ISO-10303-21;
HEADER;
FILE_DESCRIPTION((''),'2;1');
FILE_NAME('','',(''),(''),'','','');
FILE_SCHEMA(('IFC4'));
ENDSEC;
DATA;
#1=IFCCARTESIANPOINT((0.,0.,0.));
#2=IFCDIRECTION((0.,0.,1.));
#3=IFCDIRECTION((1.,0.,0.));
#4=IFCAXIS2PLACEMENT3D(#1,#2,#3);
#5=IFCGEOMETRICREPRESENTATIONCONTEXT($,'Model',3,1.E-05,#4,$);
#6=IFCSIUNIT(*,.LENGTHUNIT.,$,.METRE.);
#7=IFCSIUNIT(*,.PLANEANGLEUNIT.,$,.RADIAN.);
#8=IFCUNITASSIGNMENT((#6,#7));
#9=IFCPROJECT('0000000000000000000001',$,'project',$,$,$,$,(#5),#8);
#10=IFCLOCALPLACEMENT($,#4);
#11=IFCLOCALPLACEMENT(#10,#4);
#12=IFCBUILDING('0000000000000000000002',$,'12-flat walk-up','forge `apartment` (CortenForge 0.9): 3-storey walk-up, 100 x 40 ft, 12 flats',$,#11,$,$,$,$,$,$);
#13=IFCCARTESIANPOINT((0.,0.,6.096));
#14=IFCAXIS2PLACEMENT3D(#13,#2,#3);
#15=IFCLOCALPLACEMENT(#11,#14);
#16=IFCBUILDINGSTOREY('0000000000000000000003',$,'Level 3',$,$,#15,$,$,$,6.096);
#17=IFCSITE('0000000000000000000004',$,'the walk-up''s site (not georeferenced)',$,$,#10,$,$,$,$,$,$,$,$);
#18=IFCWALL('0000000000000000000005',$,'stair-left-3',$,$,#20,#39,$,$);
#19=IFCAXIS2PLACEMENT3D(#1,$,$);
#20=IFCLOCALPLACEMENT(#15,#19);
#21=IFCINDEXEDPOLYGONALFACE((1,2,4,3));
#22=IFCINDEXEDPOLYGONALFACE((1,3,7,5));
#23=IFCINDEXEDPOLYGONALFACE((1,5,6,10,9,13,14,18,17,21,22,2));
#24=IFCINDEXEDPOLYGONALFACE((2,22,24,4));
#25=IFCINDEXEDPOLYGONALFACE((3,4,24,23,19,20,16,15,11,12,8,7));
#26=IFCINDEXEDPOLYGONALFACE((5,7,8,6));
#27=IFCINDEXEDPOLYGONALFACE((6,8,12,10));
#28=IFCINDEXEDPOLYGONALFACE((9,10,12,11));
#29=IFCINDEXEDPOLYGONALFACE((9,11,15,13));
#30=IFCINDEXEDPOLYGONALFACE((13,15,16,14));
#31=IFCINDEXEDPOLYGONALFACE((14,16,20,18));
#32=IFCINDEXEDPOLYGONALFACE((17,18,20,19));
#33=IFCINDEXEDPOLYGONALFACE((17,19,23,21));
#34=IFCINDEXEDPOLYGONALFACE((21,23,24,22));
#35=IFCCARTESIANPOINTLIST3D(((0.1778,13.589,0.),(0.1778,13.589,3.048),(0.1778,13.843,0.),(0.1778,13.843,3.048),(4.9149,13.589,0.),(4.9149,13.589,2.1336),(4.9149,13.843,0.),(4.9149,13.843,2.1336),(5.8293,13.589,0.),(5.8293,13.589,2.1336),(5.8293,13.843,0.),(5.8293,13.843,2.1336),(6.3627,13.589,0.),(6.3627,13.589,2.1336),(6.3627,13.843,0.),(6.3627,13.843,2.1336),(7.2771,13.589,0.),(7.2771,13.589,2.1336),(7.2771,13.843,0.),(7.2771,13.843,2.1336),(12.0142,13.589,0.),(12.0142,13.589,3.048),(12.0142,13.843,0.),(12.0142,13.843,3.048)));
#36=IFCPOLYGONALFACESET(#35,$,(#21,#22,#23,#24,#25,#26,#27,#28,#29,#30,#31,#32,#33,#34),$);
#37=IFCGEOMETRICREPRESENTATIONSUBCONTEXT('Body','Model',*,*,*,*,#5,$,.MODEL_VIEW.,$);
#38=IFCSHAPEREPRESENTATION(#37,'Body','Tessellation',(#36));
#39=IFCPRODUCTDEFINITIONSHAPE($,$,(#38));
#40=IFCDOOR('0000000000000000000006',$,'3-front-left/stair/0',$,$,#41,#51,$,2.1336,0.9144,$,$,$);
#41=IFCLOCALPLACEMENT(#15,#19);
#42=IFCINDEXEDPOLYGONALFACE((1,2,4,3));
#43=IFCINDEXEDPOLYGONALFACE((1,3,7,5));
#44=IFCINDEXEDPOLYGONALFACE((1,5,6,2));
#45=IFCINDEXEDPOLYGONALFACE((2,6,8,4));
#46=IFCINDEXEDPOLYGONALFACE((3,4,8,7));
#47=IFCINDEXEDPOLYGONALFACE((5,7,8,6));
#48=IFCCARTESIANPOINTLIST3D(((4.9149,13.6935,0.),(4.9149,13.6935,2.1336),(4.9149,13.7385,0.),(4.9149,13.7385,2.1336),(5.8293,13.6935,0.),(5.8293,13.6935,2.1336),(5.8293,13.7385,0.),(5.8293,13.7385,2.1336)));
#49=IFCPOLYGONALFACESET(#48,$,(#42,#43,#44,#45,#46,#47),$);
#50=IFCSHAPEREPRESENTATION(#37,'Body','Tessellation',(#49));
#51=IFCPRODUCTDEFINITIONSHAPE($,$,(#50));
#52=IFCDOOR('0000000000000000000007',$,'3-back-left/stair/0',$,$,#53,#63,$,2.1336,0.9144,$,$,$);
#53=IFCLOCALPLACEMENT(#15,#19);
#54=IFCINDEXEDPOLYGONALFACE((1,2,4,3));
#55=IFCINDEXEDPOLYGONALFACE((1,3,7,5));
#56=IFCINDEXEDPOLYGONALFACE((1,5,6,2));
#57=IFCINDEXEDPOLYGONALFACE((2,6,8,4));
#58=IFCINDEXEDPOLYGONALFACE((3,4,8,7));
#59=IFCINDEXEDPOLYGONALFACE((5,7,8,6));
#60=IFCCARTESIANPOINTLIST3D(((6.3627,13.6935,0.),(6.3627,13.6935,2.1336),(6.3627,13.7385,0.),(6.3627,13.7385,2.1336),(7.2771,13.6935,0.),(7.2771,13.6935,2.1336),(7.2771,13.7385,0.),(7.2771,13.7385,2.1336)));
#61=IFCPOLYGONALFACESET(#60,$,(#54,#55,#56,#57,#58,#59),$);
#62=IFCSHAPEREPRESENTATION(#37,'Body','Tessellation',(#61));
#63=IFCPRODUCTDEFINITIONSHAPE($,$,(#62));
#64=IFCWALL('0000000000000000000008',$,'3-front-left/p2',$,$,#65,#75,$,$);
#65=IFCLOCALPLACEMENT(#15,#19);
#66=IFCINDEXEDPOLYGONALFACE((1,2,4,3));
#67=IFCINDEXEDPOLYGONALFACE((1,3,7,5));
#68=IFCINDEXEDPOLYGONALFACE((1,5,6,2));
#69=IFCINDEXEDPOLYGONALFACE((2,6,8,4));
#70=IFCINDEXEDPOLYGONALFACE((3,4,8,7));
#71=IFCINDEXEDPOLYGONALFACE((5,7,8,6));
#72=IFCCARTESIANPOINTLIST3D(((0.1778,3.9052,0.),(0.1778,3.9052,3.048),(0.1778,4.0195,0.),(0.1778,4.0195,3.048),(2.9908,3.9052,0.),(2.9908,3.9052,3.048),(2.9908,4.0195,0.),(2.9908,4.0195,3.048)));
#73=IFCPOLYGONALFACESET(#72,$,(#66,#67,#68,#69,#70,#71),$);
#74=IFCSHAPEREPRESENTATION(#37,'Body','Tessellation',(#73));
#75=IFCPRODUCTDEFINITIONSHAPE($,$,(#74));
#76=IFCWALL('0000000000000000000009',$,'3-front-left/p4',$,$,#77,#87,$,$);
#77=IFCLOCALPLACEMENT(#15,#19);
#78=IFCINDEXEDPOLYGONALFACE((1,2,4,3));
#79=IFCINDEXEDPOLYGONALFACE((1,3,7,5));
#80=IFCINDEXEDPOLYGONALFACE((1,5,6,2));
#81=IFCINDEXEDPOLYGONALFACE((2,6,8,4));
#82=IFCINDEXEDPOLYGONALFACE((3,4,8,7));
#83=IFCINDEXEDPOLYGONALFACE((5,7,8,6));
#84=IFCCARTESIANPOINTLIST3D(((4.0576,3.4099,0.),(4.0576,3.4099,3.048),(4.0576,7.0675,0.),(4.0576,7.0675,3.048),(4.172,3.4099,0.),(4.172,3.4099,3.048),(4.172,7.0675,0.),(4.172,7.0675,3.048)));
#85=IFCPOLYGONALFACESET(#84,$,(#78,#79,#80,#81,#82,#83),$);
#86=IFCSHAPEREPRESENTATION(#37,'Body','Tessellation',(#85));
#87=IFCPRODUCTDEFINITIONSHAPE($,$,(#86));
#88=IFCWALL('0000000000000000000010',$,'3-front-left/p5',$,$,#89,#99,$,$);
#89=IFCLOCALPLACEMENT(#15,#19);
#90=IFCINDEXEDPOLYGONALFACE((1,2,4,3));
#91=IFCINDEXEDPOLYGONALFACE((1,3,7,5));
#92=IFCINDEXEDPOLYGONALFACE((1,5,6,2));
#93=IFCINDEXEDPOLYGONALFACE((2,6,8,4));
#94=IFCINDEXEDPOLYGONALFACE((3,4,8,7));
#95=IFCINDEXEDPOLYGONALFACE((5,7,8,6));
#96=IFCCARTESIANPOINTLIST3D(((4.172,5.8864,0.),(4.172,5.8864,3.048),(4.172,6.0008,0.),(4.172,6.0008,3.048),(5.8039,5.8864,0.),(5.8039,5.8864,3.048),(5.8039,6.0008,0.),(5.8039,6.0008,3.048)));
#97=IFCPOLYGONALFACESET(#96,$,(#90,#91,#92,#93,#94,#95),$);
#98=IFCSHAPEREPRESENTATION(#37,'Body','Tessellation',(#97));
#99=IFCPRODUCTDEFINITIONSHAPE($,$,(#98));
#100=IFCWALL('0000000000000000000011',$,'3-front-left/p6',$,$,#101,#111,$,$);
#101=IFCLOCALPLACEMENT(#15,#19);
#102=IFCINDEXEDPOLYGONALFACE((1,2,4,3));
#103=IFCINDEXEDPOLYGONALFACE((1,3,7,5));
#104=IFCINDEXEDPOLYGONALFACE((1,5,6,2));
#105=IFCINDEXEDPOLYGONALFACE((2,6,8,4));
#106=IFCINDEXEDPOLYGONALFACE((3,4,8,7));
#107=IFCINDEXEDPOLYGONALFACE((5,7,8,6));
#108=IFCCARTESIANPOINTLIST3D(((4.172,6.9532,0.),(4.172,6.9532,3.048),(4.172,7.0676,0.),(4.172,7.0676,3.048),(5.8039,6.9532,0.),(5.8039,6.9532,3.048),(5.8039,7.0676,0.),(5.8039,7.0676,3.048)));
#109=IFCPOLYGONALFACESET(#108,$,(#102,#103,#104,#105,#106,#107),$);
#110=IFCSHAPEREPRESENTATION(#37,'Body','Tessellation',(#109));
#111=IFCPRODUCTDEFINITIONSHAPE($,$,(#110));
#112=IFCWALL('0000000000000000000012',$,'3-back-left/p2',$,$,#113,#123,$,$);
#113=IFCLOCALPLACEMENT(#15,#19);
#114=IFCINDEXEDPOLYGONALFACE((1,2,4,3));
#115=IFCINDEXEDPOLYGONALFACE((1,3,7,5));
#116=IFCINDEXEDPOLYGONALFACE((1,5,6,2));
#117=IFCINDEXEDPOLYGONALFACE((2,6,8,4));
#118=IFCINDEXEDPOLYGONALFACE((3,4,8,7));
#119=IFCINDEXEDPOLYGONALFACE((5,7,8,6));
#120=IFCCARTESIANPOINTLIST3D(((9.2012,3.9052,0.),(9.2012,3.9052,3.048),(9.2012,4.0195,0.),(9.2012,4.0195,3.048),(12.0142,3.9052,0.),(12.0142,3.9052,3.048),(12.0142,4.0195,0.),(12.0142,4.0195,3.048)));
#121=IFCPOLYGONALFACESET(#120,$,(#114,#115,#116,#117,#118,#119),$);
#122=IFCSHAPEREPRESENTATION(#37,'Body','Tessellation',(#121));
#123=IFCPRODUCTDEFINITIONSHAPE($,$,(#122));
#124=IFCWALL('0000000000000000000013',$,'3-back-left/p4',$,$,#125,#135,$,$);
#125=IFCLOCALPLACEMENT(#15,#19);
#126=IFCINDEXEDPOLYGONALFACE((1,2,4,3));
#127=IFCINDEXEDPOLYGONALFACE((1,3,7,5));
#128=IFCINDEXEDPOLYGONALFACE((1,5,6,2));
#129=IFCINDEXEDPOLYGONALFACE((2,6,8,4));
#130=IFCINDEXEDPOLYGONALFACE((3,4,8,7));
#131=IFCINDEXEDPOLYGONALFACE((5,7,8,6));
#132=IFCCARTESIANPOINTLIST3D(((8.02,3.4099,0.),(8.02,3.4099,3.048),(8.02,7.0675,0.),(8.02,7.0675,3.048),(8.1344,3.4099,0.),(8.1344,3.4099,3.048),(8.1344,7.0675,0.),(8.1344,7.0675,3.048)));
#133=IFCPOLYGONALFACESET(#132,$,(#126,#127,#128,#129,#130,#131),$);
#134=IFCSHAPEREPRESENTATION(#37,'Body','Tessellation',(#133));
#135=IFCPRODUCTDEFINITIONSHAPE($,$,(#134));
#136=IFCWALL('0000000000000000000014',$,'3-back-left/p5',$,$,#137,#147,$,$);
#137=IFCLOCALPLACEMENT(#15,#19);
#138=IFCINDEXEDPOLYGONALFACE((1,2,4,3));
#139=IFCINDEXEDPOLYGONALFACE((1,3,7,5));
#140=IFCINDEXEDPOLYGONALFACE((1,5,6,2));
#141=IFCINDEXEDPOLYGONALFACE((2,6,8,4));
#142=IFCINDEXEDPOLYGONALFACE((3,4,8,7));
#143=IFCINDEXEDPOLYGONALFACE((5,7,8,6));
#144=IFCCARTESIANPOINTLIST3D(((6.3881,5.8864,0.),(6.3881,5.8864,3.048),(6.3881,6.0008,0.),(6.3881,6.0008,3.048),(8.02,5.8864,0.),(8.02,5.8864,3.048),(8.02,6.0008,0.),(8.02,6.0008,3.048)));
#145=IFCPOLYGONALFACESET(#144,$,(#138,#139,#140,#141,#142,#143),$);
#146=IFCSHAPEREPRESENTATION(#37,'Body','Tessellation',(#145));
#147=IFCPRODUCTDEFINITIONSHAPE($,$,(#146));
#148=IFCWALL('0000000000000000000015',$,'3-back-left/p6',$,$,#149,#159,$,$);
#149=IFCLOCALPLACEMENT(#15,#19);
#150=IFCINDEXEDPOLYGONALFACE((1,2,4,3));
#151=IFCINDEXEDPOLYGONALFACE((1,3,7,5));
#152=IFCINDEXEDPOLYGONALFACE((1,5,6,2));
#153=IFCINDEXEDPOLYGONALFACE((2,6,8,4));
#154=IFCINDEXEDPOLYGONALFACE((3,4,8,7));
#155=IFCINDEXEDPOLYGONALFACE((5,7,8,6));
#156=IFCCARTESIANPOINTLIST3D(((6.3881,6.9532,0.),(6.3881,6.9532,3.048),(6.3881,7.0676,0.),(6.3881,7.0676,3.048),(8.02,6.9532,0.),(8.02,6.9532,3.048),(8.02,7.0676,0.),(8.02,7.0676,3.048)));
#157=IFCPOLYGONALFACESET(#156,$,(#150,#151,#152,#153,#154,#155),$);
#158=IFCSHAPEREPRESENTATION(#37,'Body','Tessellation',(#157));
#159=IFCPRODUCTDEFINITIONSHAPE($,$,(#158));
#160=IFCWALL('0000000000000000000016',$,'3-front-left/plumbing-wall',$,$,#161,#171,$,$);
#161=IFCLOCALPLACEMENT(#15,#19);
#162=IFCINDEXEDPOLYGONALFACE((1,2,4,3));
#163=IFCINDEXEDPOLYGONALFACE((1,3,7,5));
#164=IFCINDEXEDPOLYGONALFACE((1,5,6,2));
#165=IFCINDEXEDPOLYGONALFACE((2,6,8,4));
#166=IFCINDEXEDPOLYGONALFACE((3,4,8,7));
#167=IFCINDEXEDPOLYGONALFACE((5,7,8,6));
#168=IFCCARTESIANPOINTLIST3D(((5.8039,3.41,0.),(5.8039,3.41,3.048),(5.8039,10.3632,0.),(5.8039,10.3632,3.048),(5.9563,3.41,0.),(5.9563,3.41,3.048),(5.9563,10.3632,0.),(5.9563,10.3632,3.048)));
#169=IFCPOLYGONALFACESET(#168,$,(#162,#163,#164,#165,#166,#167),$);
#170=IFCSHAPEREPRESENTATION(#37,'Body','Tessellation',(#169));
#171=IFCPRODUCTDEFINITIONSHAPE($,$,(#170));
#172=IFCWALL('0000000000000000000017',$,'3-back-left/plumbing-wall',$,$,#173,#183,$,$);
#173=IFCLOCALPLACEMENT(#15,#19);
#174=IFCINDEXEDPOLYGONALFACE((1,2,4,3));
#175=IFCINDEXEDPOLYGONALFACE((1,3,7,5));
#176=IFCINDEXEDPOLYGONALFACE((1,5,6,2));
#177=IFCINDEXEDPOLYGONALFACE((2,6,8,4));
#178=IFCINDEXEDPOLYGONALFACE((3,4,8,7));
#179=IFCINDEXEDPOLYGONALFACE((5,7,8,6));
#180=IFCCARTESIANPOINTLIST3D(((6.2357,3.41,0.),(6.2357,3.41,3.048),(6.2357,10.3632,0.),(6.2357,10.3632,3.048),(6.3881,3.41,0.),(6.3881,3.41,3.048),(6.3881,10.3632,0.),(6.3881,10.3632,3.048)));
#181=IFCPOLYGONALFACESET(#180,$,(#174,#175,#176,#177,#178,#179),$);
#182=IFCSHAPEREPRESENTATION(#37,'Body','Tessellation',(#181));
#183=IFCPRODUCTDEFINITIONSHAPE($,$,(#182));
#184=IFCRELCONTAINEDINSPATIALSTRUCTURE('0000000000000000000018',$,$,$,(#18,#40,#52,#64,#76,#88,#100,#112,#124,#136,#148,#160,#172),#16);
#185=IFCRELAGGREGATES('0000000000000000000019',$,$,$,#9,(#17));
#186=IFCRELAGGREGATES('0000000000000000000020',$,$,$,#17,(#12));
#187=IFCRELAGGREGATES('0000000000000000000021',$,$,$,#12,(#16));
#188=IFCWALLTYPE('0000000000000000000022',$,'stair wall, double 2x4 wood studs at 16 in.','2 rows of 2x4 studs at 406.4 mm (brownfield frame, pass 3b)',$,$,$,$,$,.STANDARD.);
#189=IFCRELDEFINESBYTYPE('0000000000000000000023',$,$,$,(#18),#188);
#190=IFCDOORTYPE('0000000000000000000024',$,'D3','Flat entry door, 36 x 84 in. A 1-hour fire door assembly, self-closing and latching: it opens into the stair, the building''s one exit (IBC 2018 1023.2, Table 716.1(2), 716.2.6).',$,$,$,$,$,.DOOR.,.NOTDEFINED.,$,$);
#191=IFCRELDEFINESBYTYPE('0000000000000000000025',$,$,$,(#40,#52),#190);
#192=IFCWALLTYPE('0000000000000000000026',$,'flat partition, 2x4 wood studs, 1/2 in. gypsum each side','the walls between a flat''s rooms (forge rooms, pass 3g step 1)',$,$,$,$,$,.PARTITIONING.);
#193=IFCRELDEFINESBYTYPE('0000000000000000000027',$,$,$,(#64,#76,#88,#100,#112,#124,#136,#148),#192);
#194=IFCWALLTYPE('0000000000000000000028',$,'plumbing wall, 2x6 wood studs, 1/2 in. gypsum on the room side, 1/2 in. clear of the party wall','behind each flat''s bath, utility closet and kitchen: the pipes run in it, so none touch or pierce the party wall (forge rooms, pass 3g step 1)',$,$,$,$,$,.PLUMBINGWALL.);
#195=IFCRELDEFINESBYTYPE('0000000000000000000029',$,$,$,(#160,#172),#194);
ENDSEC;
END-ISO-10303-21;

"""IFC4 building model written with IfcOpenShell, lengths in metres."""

from ifc_helpers import new_model, si_unit, frame, frame_2d, origin, origin_with_axes, place, context, subcontext, project, spatial, rectangle, extrude, type_object, element, fill, save


model = new_model("IFC4")

# Units and contexts
model_context = context("Model", 3, precision=1e-05, world=origin_with_axes())
body_context = subcontext(model_context, "Body", "Model", "MODEL_VIEW")
ifc_project = project(units=[si_unit("LENGTHUNIT", "METRE"), si_unit("PLANEANGLEUNIT", "RADIAN")], contexts=[model_context])

# Site, building, storey
site_placement = place(None, origin_with_axes())
site = spatial("IfcSite", under=ifc_project, at=site_placement, Name="the walk-up's site (not georeferenced)")
building_placement = place(site_placement, origin_with_axes())
building = spatial("IfcBuilding", under=site, at=building_placement, Name="12-flat walk-up", Description="forge `apartment` (CortenForge 0.9): 3-storey walk-up, 100 x 40 ft, 12 flats")
storey_placement = place(building_placement, frame((0.0, 0.0, 6.096), z_axis=(0.0, 0.0, 1.0), x_axis=(1.0, 0.0, 0.0)))
storey = spatial("IfcBuildingStorey", under=building, at=storey_placement, Name="Level 3", Elevation=6.096)

# Wall, openings, doors
wall_type_1 = type_object("IfcWallType", Name="stair wall, double 2x4 wood studs at 16 in.", Description="2 rows of 2x4 studs at 406.4 mm (brownfield frame, pass 3b)", PredefinedType="STANDARD")
wall_1_placement = place(storey_placement, frame((0.1778, 13.589, 0.0), z_axis=(0.0, 0.0, 1.0), x_axis=(1.0, 0.0, 0.0)))
wall_1 = element("IfcWall", 1, at=wall_1_placement, inside=storey, type_object=wall_type_1, Name="stair-left-3", context=body_context, shape_type="SweptSolid", body=[
    extrude(rectangle(XDim=11.8364, YDim=0.254, at=frame_2d((5.9182, 0.127))), origin(), (0.0, 0.0, 1.0), 3.048),
])
opening_1_placement = place(wall_1_placement, frame((4.7371, 0.0, 0.0), z_axis=(0.0, 0.0, 1.0), x_axis=(1.0, 0.0, 0.0)))
opening_1 = element("IfcOpeningElement", 2, at=opening_1_placement, cuts=wall_1, PredefinedType="OPENING", context=body_context, shape_type="SweptSolid", body=[
    extrude(rectangle(XDim=0.9144, YDim=0.254, at=frame_2d((0.4572, 0.127))), origin(), (0.0, 0.0, 1.0), 2.1336),
])
opening_2_placement = place(wall_1_placement, frame((6.1849, 0.0, 0.0), z_axis=(0.0, 0.0, 1.0), x_axis=(1.0, 0.0, 0.0)))
opening_2 = element("IfcOpeningElement", 3, at=opening_2_placement, cuts=wall_1, PredefinedType="OPENING", context=body_context, shape_type="SweptSolid", body=[
    extrude(rectangle(XDim=0.9144, YDim=0.254, at=frame_2d((0.4572, 0.127))), origin(), (0.0, 0.0, 1.0), 2.1336),
])
door_type = type_object("IfcDoorType", Name="D3", Description="Flat entry door, 36 x 84 in. A 1-hour fire door assembly, self-closing and latching: it opens into the stair, the building's one exit (IBC 2018 1023.2, Table 716.1(2), 716.2.6).", OperationType="NOTDEFINED", PredefinedType="DOOR")
door_1_placement = place(opening_1_placement, frame((0.0, 0.1045, 0.0), z_axis=(0.0, 0.0, 1.0), x_axis=(1.0, 0.0, 0.0)))
door_1 = element("IfcDoor", 4, at=door_1_placement, inside=storey, type_object=door_type, Name="3-front-left/stair/0", OverallHeight=2.1336, OverallWidth=0.9144, context=body_context, shape_type="SweptSolid", body=[
    extrude(rectangle(XDim=0.9144, YDim=0.045, at=frame_2d((0.4572, 0.0225))), origin(), (0.0, 0.0, 1.0), 2.1336),
])
fill(opening_1, door_1)
door_2_placement = place(opening_2_placement, frame((0.0, 0.1045, 0.0), z_axis=(0.0, 0.0, 1.0), x_axis=(1.0, 0.0, 0.0)))
door_2 = element("IfcDoor", 5, at=door_2_placement, inside=storey, type_object=door_type, Name="3-back-left/stair/0", OverallHeight=2.1336, OverallWidth=0.9144, context=body_context, shape_type="SweptSolid", body=[
    extrude(rectangle(XDim=0.9144, YDim=0.045, at=frame_2d((0.4572, 0.0225))), origin(), (0.0, 0.0, 1.0), 2.1336),
])
fill(opening_2, door_2)

# Walls
wall_type_2 = type_object("IfcWallType", Name="flat partition, 2x4 wood studs, 1/2 in. gypsum each side", Description="the walls between a flat's rooms (forge rooms, pass 3g step 1)", PredefinedType="PARTITIONING")
wall_2_placement = place(storey_placement, frame((0.1778, 3.9052, 0.0), z_axis=(0.0, 0.0, 1.0), x_axis=(1.0, 0.0, 0.0)))
element("IfcWall", 6, at=wall_2_placement, inside=storey, type_object=wall_type_2, Name="3-front-left/p2", context=body_context, shape_type="SweptSolid", body=[
    extrude(rectangle(XDim=2.8131, YDim=0.1143, at=frame_2d((1.4065, 0.0571))), origin(), (0.0, 0.0, 1.0), 3.048),
])
wall_3_placement = place(storey_placement, frame((4.0576, 3.4099, 0.0), z_axis=(0.0, 0.0, 1.0), x_axis=(1.0, 0.0, 0.0)))
element("IfcWall", 7, at=wall_3_placement, inside=storey, type_object=wall_type_2, Name="3-front-left/p4", context=body_context, shape_type="SweptSolid", body=[
    extrude(rectangle(XDim=0.1143, YDim=3.6576, at=frame_2d((0.0572, 1.8288))), origin(), (0.0, 0.0, 1.0), 3.048),
])
for number, where, z_axis, x_axis, name in (
    (8, (4.1719, 5.8864, 0.0), (0.0, 0.0, 1.0), (1.0, 0.0, 0.0), "3-front-left/p5"),
    (9, (4.1719, 6.9532, 0.0), (0.0, 0.0, 1.0), (1.0, 0.0, 0.0), "3-front-left/p6"),
):
    element("IfcWall", number, at=place(storey_placement, frame(where, z_axis=z_axis, x_axis=x_axis)), inside=storey, type_object=wall_type_2, Name=name, context=body_context, shape_type="SweptSolid", body=[
        extrude(rectangle(XDim=1.6319, YDim=0.1143, at=frame_2d((0.816, 0.0572))), origin(), (0.0, 0.0, 1.0), 3.048),
    ])
wall_4_placement = place(storey_placement, frame((9.2012, 3.9052, 0.0), z_axis=(0.0, 0.0, 1.0), x_axis=(1.0, 0.0, 0.0)))
element("IfcWall", 10, at=wall_4_placement, inside=storey, type_object=wall_type_2, Name="3-back-left/p2", context=body_context, shape_type="SweptSolid", body=[
    extrude(rectangle(XDim=2.8131, YDim=0.1143, at=frame_2d((1.4065, 0.0571))), origin(), (0.0, 0.0, 1.0), 3.048),
])
wall_5_placement = place(storey_placement, frame((8.02, 3.4099, 0.0), z_axis=(0.0, 0.0, 1.0), x_axis=(1.0, 0.0, 0.0)))
element("IfcWall", 11, at=wall_5_placement, inside=storey, type_object=wall_type_2, Name="3-back-left/p4", context=body_context, shape_type="SweptSolid", body=[
    extrude(rectangle(XDim=0.1143, YDim=3.6576, at=frame_2d((0.0572, 1.8288))), origin(), (0.0, 0.0, 1.0), 3.048),
])
for number, where, z_axis, x_axis, name in (
    (12, (6.3881, 5.8864, 0.0), (0.0, 0.0, 1.0), (1.0, 0.0, 0.0), "3-back-left/p5"),
    (13, (6.3881, 6.9532, 0.0), (0.0, 0.0, 1.0), (1.0, 0.0, 0.0), "3-back-left/p6"),
):
    element("IfcWall", number, at=place(storey_placement, frame(where, z_axis=z_axis, x_axis=x_axis)), inside=storey, type_object=wall_type_2, Name=name, context=body_context, shape_type="SweptSolid", body=[
        extrude(rectangle(XDim=1.6319, YDim=0.1143, at=frame_2d((0.816, 0.0572))), origin(), (0.0, 0.0, 1.0), 3.048),
    ])
wall_type_3 = type_object("IfcWallType", Name="plumbing wall, 2x6 wood studs, 1/2 in. gypsum on the room side, 1/2 in. clear of the party wall", Description="behind each flat's bath, utility closet and kitchen: the pipes run in it, so none touch or pierce the party wall (forge rooms, pass 3g step 1)", PredefinedType="PLUMBINGWALL")
for number, where, z_axis, x_axis, name in (
    (14, (5.8039, 3.41, 0.0), (0.0, 0.0, 1.0), (1.0, 0.0, 0.0), "3-front-left/plumbing-wall"),
    (15, (6.2357, 3.41, 0.0), (0.0, 0.0, 1.0), (1.0, 0.0, 0.0), "3-back-left/plumbing-wall"),
):
    element("IfcWall", number, at=place(storey_placement, frame(where, z_axis=z_axis, x_axis=x_axis)), inside=storey, type_object=wall_type_3, Name=name, context=body_context, shape_type="SweptSolid", body=[
        extrude(rectangle(XDim=0.1524, YDim=6.9533, at=frame_2d((0.0762, 3.4766))), origin(), (0.0, 0.0, 1.0), 3.048),
    ])

save(model, "model.ifc")
